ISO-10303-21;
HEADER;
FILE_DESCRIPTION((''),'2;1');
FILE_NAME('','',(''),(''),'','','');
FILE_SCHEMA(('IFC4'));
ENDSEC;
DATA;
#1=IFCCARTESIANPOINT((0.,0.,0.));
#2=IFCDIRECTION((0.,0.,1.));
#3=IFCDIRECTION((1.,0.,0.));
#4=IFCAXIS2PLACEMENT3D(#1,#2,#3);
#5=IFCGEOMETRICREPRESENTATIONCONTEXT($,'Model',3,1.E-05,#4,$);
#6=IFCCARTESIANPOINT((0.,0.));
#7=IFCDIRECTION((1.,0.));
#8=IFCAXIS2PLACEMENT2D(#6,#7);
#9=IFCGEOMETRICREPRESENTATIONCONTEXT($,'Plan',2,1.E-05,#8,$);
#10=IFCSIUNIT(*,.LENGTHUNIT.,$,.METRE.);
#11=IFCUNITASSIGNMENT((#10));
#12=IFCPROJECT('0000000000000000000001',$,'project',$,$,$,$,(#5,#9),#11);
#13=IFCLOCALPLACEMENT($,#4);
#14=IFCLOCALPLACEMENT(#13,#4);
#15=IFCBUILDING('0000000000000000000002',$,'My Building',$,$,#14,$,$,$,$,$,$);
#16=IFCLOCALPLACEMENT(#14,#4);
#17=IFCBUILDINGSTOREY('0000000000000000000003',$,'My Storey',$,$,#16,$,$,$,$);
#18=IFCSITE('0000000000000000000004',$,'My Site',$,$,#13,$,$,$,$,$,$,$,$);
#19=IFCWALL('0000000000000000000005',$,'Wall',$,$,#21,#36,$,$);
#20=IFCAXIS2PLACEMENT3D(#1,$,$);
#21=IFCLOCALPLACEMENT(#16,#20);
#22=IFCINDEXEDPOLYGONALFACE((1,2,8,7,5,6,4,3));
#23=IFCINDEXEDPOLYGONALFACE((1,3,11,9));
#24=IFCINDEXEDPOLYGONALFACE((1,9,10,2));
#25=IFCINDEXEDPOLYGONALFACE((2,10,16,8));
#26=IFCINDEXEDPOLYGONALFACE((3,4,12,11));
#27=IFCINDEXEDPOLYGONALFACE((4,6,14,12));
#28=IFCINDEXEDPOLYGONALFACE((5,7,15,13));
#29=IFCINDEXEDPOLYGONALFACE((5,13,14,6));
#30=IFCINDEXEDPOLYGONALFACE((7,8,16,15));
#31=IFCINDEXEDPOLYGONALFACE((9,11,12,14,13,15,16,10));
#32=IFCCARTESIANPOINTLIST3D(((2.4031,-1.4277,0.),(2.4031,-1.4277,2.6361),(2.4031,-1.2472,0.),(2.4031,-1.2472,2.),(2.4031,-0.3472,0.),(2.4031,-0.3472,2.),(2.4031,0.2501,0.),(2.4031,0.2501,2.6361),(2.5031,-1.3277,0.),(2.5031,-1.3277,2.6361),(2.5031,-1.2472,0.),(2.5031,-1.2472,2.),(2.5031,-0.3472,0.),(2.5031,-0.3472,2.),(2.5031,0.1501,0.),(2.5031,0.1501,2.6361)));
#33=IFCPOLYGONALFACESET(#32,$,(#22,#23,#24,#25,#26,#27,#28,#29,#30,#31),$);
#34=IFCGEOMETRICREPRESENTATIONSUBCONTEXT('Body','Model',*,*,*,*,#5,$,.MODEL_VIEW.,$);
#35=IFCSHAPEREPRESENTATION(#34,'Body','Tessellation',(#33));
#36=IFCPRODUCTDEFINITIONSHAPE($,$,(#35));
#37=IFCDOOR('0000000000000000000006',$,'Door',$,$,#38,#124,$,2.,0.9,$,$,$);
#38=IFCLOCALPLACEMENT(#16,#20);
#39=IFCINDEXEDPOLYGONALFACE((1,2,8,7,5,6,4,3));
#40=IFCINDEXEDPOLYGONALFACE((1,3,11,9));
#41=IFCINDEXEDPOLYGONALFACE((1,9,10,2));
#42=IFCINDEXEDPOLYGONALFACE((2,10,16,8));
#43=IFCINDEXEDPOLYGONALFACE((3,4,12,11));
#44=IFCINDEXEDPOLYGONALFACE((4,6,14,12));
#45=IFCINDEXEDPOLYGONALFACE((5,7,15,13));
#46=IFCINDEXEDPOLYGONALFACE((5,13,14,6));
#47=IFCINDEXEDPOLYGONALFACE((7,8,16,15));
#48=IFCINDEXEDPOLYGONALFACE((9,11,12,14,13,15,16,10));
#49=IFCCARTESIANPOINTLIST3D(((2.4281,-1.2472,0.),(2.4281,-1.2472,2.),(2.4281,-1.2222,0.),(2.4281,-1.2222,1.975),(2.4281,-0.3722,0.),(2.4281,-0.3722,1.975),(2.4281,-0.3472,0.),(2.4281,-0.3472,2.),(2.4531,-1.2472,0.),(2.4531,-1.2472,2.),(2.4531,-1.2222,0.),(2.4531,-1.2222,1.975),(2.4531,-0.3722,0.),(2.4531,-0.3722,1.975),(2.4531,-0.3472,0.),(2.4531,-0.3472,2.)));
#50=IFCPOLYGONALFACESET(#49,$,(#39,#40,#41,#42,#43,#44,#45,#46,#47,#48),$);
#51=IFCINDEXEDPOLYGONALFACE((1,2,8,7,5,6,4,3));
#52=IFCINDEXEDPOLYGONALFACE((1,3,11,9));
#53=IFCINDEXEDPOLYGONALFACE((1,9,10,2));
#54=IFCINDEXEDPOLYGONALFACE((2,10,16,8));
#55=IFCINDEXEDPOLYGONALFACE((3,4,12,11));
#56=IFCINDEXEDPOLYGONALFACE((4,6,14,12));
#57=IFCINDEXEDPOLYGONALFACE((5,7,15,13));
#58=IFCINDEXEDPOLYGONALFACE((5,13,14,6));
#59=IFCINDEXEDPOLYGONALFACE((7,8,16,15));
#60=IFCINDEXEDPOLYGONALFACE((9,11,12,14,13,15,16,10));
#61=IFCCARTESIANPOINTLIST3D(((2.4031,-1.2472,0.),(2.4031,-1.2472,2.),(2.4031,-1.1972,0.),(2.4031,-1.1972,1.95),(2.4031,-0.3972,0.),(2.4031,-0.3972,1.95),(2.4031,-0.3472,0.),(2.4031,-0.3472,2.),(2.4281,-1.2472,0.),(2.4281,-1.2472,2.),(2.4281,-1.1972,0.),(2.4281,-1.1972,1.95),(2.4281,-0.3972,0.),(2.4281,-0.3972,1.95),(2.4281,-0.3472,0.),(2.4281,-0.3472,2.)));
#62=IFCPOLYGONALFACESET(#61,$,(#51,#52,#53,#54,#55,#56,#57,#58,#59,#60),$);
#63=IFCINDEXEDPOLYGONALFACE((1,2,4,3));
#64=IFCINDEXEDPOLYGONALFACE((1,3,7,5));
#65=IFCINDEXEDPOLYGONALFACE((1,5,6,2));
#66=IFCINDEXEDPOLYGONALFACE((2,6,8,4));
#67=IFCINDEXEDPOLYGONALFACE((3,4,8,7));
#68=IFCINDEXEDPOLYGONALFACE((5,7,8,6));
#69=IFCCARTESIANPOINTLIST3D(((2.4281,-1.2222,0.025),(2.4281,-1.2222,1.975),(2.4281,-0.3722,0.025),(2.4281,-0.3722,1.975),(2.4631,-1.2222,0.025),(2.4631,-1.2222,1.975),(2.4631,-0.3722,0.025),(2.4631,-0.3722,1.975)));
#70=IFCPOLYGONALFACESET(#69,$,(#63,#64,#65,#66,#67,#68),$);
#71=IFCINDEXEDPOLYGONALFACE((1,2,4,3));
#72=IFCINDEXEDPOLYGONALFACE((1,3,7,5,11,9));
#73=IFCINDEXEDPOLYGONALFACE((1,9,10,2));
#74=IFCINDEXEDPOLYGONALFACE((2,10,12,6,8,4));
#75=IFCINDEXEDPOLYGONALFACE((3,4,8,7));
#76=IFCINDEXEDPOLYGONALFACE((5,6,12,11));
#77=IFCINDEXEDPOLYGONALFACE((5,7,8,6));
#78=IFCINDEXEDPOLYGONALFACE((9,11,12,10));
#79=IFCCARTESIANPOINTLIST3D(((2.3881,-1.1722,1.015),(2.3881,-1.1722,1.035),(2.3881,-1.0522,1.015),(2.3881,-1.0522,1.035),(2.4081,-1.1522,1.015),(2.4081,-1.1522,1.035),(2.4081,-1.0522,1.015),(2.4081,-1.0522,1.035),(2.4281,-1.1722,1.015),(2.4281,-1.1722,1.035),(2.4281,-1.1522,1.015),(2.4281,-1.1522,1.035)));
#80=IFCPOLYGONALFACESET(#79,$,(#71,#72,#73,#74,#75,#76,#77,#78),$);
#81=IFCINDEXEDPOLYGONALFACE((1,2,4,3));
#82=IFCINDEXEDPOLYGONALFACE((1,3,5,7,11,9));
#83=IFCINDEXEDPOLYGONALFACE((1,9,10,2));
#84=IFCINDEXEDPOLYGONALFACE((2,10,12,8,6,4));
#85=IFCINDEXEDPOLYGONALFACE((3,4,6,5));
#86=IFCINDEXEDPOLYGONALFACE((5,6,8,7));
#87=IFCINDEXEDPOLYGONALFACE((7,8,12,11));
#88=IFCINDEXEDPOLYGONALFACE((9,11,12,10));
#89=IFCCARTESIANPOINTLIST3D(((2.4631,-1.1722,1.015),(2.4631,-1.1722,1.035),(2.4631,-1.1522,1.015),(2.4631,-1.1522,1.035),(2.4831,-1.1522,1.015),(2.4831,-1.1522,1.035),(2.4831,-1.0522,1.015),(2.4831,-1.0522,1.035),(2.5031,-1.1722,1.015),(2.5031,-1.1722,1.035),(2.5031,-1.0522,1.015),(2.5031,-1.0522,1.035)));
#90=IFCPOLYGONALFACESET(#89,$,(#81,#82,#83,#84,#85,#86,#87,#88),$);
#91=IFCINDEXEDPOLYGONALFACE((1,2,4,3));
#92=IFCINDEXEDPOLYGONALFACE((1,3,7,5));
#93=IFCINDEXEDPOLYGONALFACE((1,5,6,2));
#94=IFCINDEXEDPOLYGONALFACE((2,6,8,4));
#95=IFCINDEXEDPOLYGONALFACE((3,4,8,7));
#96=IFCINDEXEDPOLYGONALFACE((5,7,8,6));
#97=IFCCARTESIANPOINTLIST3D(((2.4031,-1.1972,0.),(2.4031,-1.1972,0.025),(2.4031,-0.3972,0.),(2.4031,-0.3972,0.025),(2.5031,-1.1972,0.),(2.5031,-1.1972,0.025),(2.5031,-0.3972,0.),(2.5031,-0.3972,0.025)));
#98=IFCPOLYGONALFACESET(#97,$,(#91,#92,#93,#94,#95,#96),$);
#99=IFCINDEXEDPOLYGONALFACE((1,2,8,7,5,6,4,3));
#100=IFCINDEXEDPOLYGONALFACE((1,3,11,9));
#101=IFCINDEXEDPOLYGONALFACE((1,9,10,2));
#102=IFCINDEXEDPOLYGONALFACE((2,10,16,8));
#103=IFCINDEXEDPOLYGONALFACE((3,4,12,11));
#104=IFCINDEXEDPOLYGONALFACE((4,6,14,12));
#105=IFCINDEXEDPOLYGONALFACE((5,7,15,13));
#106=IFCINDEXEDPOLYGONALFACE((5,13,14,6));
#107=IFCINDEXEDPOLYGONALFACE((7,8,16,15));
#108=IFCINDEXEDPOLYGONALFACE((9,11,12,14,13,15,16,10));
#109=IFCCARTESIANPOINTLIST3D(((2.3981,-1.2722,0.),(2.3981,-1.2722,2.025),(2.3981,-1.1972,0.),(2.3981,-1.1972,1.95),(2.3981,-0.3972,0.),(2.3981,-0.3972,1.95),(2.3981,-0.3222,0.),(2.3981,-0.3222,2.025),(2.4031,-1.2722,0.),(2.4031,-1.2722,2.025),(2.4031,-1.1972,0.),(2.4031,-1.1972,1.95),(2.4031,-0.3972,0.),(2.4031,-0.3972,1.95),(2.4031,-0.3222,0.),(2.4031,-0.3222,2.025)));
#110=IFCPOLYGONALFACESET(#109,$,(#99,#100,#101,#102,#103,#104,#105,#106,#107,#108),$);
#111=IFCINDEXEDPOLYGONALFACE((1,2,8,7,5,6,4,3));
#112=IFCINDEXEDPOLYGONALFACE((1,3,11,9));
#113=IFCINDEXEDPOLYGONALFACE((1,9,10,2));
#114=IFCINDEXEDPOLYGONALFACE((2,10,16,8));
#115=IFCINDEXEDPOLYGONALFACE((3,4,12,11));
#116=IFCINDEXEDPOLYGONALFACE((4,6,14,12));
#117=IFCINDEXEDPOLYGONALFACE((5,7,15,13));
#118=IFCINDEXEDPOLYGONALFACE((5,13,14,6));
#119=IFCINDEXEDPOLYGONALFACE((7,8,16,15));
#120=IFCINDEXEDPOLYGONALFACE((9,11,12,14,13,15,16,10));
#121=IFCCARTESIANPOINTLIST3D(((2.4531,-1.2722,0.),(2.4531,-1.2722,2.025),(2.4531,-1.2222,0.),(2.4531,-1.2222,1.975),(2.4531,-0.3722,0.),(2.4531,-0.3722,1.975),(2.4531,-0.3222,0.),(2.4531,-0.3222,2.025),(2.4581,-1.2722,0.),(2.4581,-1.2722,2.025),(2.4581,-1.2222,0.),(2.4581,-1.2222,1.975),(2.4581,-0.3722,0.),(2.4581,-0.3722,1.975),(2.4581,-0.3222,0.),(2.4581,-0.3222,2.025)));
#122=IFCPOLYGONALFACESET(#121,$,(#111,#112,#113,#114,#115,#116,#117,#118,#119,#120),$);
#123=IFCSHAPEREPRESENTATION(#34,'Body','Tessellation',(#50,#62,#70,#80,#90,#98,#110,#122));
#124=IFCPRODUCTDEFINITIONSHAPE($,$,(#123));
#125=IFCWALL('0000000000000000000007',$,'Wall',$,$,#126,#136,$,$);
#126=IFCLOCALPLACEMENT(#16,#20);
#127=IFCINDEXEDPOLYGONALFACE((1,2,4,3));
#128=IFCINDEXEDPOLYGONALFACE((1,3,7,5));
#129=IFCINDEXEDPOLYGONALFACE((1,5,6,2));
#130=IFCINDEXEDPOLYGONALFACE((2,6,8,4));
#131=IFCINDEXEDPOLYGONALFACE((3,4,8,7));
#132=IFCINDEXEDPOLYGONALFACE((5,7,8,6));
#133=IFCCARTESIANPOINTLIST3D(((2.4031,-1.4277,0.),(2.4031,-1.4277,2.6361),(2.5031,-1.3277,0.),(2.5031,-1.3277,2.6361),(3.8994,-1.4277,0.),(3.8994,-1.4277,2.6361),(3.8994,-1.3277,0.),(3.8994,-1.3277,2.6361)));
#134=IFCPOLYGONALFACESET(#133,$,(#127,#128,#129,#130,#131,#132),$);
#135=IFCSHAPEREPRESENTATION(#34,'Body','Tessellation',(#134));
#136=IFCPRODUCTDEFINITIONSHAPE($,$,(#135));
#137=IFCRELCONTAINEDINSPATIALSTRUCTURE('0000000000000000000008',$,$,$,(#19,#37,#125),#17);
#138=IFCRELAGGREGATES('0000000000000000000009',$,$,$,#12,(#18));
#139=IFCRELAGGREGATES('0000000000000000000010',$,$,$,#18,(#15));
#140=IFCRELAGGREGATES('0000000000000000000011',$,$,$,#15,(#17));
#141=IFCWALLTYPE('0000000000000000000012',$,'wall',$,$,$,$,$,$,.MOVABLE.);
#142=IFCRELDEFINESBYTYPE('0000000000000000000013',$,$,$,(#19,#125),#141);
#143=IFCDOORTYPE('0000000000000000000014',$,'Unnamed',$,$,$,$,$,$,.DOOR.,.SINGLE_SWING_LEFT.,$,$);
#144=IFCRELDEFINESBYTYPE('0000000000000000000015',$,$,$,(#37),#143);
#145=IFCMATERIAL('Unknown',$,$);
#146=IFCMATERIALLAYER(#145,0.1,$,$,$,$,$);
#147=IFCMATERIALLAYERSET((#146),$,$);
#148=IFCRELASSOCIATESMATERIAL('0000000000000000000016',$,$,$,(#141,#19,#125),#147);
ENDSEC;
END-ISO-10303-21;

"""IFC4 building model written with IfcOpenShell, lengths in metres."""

from ifc_helpers import new_model, entity, si_unit, frame, origin_with_axes, origin_2d_with_axis, place, context, subcontext, project, spatial, line, indexed_curve, outline, extrude, shape, source, transform, mapped, material, layer, layer_set, layer_usage, type_object, type_shapes, element, fill, save


model = new_model("IFC4")

# Units and contexts
model_context = context("Model", 3, precision=1e-05, world=origin_with_axes())
plan_context = context("Plan", 2, precision=1e-05, world=origin_2d_with_axis())
body_context_1 = subcontext(model_context, "Body", "Model", "MODEL_VIEW")
body_context_2 = subcontext(plan_context, "Body", "Plan", "PLAN_VIEW")
ifc_project = project(units=[si_unit("LENGTHUNIT", "METRE")], contexts=[model_context, plan_context])

# Site, building, storey
site_placement = place(None, origin_with_axes())
site = spatial("IfcSite", under=ifc_project, at=site_placement, Name="My Site")
building_placement = place(site_placement, origin_with_axes())
building = spatial("IfcBuilding", under=site, at=building_placement, Name="My Building")
storey_placement = place(building_placement, origin_with_axes())
storey = spatial("IfcBuildingStorey", under=building, at=storey_placement, Name="My Storey")

# Shared definitions
ifc_material = material(Name="Unknown")

# Shared definitions
ifc_layer_1 = layer(ifc_material, 0.1)
ifc_layer_set_1 = layer_set([ifc_layer_1])
wall_type_1 = type_object("IfcWallType", Name="wall", PredefinedType="MOVABLE", material=ifc_layer_set_1)

# Wall, opening, door
ifc_layer_usage_1 = layer_usage(ifc_layer_set_1, "AXIS2", "POSITIVE", 0.0)
wall_1_placement = place(storey_placement, frame((2.4031, 0.2501, 0.0), z_axis=(0.0, 0.0, 1.0), x_axis=(0.0, -1.0, 0.0)))
wall_1 = element("IfcWall", 1, at=wall_1_placement, inside=storey, type_object=wall_type_1, material=ifc_layer_usage_1, Name="Wall", context=body_context_1, shape_type="SweptSolid", body=[
    extrude(outline(indexed_curve([(0.0, 0.0), (0.1, 0.1), (1.5778, 0.1), (1.6778, 0.0)], segments=[line(1, 2, 3, 4, 1)])), origin_with_axes(), (0.0, 0.0, 1.0), 2.6361),
])
shared_shape_1 = source(origin_with_axes(), body_context_1, "Body", "SweptSolid", [
    extrude(outline(indexed_curve([(0.0, 0.0), (0.9, 0.0), (0.9, 2.0), (0.0, 2.0)], segments=[line(1, 2, 3, 4, 1)])), frame((0.0, -0.6, 0.0), z_axis=(0.0, -1.0, 0.0), x_axis=(1.0, 0.0, 0.0)), (0.0, 0.0, -1.0), 1.2),
])
opening_placement = place(wall_1_placement, frame((0.5973, 0.0, 0.0), z_axis=(0.0, 0.0, 1.0), x_axis=(1.0, 0.0, 0.0)))
opening = element("IfcOpeningElement", 2, at=opening_placement, cuts=wall_1, PredefinedType="OPENING", context=body_context_1, shape_type="MappedRepresentation", body=[
    mapped(shared_shape_1, transform((0.0, 0.0, 0.0), x_axis=(1.0, 0.0, 0.0), y_axis=(0.0, 1.0, 0.0), z_axis=(0.0, 0.0, 1.0), scale=1.0)),
])
door_type_1 = type_object("IfcDoorType", Name="Unnamed", OperationType="SINGLE_SWING_LEFT", PredefinedType="DOOR")
shared_shape_2 = source(origin_with_axes(), body_context_1, "Body", "SweptSolid", [
    extrude(outline(indexed_curve([(0.0, 0.0), (0.0, 2.0), (0.9, 2.0), (0.9, 0.0), (0.875, 0.0), (0.875, 1.975), (0.025, 1.975), (0.025, 0.0)], segments=[line(1, 2, 3, 4, 5, 6, 7, 8, 1)])), frame((0.0, 0.025, 0.0), z_axis=(0.0, -1.0, 0.0), x_axis=(1.0, 0.0, 0.0)), (0.0, 0.0, -1.0), 0.025),
    extrude(outline(indexed_curve([(0.0, 0.0), (0.0, 2.0), (0.9, 2.0), (0.9, 0.0), (0.85, 0.0), (0.85, 1.95), (0.05, 1.95), (0.05, 0.0)], segments=[line(1, 2, 3, 4, 5, 6, 7, 8, 1)])), frame((0.0, 0.0, 0.0), z_axis=(0.0, -1.0, 0.0), x_axis=(1.0, 0.0, 0.0)), (0.0, 0.0, -1.0), 0.025),
    extrude(outline(indexed_curve([(0.0, 0.0), (0.85, 0.0), (0.85, 0.035), (0.0, 0.035)], segments=[line(1, 2, 3, 4, 1)])), frame((0.025, 0.025, 0.025), z_axis=(0.0, 0.0, 1.0), x_axis=(1.0, 0.0, 0.0)), (0.0, 0.0, 1.0), 1.95),
    extrude(outline(indexed_curve([(0.0, 0.0), (0.0, -0.04), (-0.12, -0.04), (-0.12, -0.02), (-0.02, -0.02), (-0.02, 0.0)], segments=[line(1, 2, 3, 4, 5, 6, 1)])), frame((0.825, 0.025, 1.015), z_axis=(0.0, 0.0, 1.0), x_axis=(1.0, 0.0, 0.0)), (0.0, 0.0, 1.0), 0.02),
    extrude(outline(indexed_curve([(0.0, 0.0), (0.0, 0.04), (-0.12, 0.04), (-0.12, 0.02), (-0.02, 0.02), (-0.02, 0.0)], segments=[line(1, 2, 3, 4, 5, 6, 1)])), frame((0.825, 0.06, 1.015), z_axis=(0.0, 0.0, 1.0), x_axis=(1.0, 0.0, 0.0)), (0.0, 0.0, 1.0), 0.02),
    extrude(outline(indexed_curve([(0.0, 0.0), (0.8, 0.0), (0.8, 0.1), (0.0, 0.1)], segments=[line(1, 2, 3, 4, 1)])), frame((0.05, 0.0, 0.0), z_axis=(0.0, 0.0, 1.0), x_axis=(1.0, 0.0, 0.0)), (0.0, 0.0, 1.0), 0.025),
    extrude(outline(indexed_curve([(0.0, 0.0), (0.0, 2.025), (0.95, 2.025), (0.95, 0.0), (0.875, 0.0), (0.875, 1.95), (0.075, 1.95), (0.075, 0.0)], segments=[line(1, 2, 3, 4, 5, 6, 7, 8, 1)])), frame((-0.025, -0.005, 0.0), z_axis=(0.0, -1.0, 0.0), x_axis=(1.0, 0.0, 0.0)), (0.0, 0.0, -1.0), 0.005),
    extrude(outline(indexed_curve([(0.0, 0.0), (0.0, 2.025), (0.95, 2.025), (0.95, 0.0), (0.9, 0.0), (0.9, 1.975), (0.05, 1.975), (0.05, 0.0)], segments=[line(1, 2, 3, 4, 5, 6, 7, 8, 1)])), frame((-0.025, 0.05, 0.0), z_axis=(0.0, -1.0, 0.0), x_axis=(1.0, 0.0, 0.0)), (0.0, 0.0, -1.0), 0.005),
])
shared_shape_3 = source(origin_with_axes(), body_context_2, "Body", "Curve2D", [
    entity("IfcIndexedPolyCurve", entity("IfcCartesianPointList2D", [[0.0, 0.0], [0.0, 0.05], [0.025, 0.05], [0.025, 0.025], [0.05, 0.025], [0.05, 0.0]]), [entity("IfcLineIndex", [1, 2, 3, 4, 5, 6, 1])]),
    entity("IfcIndexedPolyCurve", entity("IfcCartesianPointList2D", [[0.9, 0.0], [0.9, 0.05], [0.875, 0.05], [0.875, 0.025], [0.85, 0.025], [0.85, 0.0]]), [entity("IfcLineIndex", [1, 2, 3, 4, 5, 6, 1])]),
    entity("IfcTrimmedCurve", entity("IfcEllipse", entity("IfcAxis2Placement2D", entity("IfcCartesianPoint", [0.06, 0.05]), entity("IfcDirection", [1.0, 0.0])), 0.815, 0.85), [entity("IfcCartesianPoint", [0.875, 0.05])], [entity("IfcCartesianPoint", [0.06, 0.9])], True, "CARTESIAN"),
    entity("IfcIndexedPolyCurve", entity("IfcCartesianPointList2D", [[0.025, 0.05], [0.06, 0.05], [0.06, 0.9], [0.025, 0.9]]), [entity("IfcLineIndex", [1, 2, 3, 4, 1])]),
])
type_shapes(door_type_1, [shared_shape_2, shared_shape_3])
door_1_placement = place(opening_placement, frame((0.0, 0.0, 0.0), z_axis=(0.0, 0.0, 1.0), x_axis=(1.0, 0.0, 0.0)))
door_1 = element("IfcDoor", 3, at=door_1_placement, inside=storey, type_object=door_type_1, Name="Door", OverallHeight=2.0, OverallWidth=0.9, shapes=[
    shape(body_context_1, "Body", "MappedRepresentation", [mapped(shared_shape_2, transform((0.0, 0.0, 0.0), x_axis=(1.0, 0.0, 0.0), y_axis=(0.0, 1.0, 0.0), z_axis=(0.0, 0.0, 1.0), scale=1.0))]),
    shape(body_context_2, "Body", "MappedRepresentation", [mapped(shared_shape_3, transform((0.0, 0.0, 0.0), x_axis=(1.0, 0.0, 0.0), y_axis=(0.0, 1.0, 0.0), z_axis=(0.0, 0.0, 1.0), scale=1.0))]),
])
fill(opening, door_1)

# Wall
ifc_layer_usage_2 = layer_usage(ifc_layer_set_1, "AXIS2", "POSITIVE", 0.0)
wall_2_placement = place(storey_placement, frame((2.4031, -1.4277, 0.0), z_axis=(0.0, 0.0, 1.0), x_axis=(1.0, 0.0, 0.0)))
element("IfcWall", 4, at=wall_2_placement, inside=storey, type_object=wall_type_1, material=ifc_layer_usage_2, Name="Wall", context=body_context_1, shape_type="SweptSolid", body=[
    extrude(outline(indexed_curve([(0.0, 0.0), (0.1, 0.1), (1.4963, 0.1), (1.4963, 0.0)], segments=[line(1, 2, 3, 4, 1)])), origin_with_axes(), (0.0, 0.0, 1.0), 2.6361),
])

save(model, "model.ifc")
